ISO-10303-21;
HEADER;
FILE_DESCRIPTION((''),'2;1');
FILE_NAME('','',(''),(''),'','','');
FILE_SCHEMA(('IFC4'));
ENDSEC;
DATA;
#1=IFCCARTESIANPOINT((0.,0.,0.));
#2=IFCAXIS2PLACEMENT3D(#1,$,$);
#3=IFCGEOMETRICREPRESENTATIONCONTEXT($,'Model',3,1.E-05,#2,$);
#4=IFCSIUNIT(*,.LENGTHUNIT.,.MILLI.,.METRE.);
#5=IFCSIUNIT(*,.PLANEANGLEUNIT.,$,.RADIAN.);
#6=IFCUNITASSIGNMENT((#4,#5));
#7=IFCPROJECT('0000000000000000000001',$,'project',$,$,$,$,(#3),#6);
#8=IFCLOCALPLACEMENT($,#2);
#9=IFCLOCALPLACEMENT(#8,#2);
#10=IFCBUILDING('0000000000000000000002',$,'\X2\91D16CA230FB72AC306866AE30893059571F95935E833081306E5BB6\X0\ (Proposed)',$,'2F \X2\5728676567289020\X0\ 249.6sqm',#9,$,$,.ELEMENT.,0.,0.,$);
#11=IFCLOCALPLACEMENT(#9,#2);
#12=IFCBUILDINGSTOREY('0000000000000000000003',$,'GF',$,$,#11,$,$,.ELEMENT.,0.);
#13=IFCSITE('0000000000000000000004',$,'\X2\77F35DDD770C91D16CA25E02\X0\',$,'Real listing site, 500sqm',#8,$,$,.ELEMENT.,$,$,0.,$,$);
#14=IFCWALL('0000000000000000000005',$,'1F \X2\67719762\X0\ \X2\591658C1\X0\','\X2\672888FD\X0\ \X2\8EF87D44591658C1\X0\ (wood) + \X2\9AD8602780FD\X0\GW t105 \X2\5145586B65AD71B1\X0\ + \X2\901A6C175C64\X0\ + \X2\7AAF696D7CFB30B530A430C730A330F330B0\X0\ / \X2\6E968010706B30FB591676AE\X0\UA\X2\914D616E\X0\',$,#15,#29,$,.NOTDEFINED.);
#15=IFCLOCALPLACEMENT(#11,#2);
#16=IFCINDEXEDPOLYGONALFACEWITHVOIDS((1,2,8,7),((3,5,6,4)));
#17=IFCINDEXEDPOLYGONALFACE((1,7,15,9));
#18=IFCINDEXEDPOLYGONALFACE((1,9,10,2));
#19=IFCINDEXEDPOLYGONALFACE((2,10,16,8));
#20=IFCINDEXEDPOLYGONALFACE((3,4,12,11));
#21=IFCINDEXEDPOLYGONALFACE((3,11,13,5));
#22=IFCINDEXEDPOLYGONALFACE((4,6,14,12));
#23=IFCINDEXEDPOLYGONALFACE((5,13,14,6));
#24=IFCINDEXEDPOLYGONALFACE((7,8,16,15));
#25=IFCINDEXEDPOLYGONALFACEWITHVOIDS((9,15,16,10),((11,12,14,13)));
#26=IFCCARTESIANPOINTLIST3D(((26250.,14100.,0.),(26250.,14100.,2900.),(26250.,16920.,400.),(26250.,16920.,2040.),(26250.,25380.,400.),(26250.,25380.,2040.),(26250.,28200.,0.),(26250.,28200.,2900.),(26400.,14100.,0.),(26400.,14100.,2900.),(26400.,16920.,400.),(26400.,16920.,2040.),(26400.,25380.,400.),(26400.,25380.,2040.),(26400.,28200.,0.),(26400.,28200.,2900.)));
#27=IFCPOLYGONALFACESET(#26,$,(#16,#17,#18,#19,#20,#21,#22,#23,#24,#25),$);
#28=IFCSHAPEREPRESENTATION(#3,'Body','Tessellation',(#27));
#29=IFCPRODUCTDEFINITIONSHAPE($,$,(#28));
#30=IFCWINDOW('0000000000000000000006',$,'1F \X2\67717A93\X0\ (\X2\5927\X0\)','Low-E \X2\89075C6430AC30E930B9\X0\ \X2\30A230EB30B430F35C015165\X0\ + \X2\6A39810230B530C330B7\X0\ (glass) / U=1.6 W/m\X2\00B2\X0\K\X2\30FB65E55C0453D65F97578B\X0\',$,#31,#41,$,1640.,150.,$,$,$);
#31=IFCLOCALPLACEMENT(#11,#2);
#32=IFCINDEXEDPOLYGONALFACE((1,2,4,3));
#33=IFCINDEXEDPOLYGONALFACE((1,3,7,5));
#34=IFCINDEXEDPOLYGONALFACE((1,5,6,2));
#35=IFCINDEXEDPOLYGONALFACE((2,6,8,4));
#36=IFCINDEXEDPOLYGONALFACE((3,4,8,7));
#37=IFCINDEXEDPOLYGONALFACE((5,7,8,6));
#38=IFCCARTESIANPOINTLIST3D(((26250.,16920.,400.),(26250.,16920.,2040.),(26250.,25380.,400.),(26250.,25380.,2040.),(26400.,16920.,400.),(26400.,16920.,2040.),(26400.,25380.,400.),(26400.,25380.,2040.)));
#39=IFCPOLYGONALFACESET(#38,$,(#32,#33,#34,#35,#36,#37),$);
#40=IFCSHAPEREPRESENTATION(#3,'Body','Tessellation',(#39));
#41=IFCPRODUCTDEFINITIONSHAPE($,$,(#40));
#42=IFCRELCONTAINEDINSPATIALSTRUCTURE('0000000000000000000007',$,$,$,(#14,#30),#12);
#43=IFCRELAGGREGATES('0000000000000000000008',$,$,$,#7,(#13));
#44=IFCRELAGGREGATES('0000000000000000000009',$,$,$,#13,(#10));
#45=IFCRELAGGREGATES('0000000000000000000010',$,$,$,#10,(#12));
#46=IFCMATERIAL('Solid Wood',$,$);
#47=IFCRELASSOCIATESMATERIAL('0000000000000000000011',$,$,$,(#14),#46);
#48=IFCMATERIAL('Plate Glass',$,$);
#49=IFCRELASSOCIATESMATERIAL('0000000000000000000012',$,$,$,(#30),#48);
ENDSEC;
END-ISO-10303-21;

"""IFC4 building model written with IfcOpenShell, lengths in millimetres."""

from ifc_helpers import new_model, si_unit, frame, frame_2d, origin, place, context, project, spatial, rectangle, extrude, material, element, fill, save


model = new_model("IFC4")

# Units and contexts
model_context = context("Model", 3, precision=1e-05, world=origin())
ifc_project = project(units=[si_unit("LENGTHUNIT", "METRE", prefix="MILLI"), si_unit("PLANEANGLEUNIT", "RADIAN")], contexts=[model_context])

# Site, building, storey
site_placement = place(None, origin())
site = spatial("IfcSite", under=ifc_project, at=site_placement, Name="石川県金沢市", ObjectType="Real listing site, 500sqm", CompositionType="ELEMENT", RefElevation=0.0)
building_placement = place(site_placement, origin())
building = spatial("IfcBuilding", under=site, at=building_placement, Name="金沢・犬と暮らす土間広めの家 (Proposed)", ObjectType="2F 在来木造 249.6sqm", CompositionType="ELEMENT", ElevationOfRefHeight=0.0, ElevationOfTerrain=0.0)
storey_placement = place(building_placement, origin())
storey = spatial("IfcBuildingStorey", under=building, at=storey_placement, Name="GF", CompositionType="ELEMENT", Elevation=0.0)

# Shared definitions
ifc_material_1 = material(Name="Solid Wood")

# Wall, opening, window
wall_1_placement = place(storey_placement, frame((13125.0, 7050.0, 0.0)))
wall_1 = element("IfcWall", 1, at=wall_1_placement, inside=storey, material=ifc_material_1, Name="1F 東面 外壁", Description="木製 軸組外壁 (wood) + 高性能GW t105 充填断熱 + 通気層 + 窯業系サイディング / 準耐火・外皮UA配慮", PredefinedType="NOTDEFINED", context=model_context, shape_type="SweptSolid", body=[
    extrude(rectangle(XDim=150.0, YDim=14100.0, at=frame_2d((75.0, 7050.0))), frame((13125.0, 7050.0, 0.0)), (0.0, 0.0, 1.0), 2900.0),
])
opening_1_placement = place(storey_placement, frame((13125.0, 8460.0, 200.0)))
opening_1 = element("IfcOpeningElement", 2, at=opening_1_placement, cuts=wall_1, PredefinedType="NOTDEFINED", context=model_context, shape_type="SweptSolid", body=[
    extrude(rectangle(XDim=150.0, YDim=8460.0, at=frame_2d((75.0, 4230.0))), frame((13125.0, 8460.0, 200.0)), (0.0, 0.0, 1.0), 1640.0),
])
ifc_material_2 = material(Name="Plate Glass")
window_1_placement = place(storey_placement, frame((13125.0, 8460.0, 200.0)))
window_1 = element("IfcWindow", 3, at=window_1_placement, inside=storey, material=ifc_material_2, Name="1F 東窓 (大)", Description="Low-E 複層ガラス アルゴン封入 + 樹脂サッシ (glass) / U=1.6 W/m²K・日射取得型", OverallHeight=1640.0, OverallWidth=150.0, context=model_context, shape_type="SweptSolid", body=[
    extrude(rectangle(XDim=150.0, YDim=8460.0, at=frame_2d((75.0, 4230.0))), frame((13125.0, 8460.0, 200.0)), (0.0, 0.0, 1.0), 1640.0),
])
fill(opening_1, window_1)

save(model, "model.ifc")
